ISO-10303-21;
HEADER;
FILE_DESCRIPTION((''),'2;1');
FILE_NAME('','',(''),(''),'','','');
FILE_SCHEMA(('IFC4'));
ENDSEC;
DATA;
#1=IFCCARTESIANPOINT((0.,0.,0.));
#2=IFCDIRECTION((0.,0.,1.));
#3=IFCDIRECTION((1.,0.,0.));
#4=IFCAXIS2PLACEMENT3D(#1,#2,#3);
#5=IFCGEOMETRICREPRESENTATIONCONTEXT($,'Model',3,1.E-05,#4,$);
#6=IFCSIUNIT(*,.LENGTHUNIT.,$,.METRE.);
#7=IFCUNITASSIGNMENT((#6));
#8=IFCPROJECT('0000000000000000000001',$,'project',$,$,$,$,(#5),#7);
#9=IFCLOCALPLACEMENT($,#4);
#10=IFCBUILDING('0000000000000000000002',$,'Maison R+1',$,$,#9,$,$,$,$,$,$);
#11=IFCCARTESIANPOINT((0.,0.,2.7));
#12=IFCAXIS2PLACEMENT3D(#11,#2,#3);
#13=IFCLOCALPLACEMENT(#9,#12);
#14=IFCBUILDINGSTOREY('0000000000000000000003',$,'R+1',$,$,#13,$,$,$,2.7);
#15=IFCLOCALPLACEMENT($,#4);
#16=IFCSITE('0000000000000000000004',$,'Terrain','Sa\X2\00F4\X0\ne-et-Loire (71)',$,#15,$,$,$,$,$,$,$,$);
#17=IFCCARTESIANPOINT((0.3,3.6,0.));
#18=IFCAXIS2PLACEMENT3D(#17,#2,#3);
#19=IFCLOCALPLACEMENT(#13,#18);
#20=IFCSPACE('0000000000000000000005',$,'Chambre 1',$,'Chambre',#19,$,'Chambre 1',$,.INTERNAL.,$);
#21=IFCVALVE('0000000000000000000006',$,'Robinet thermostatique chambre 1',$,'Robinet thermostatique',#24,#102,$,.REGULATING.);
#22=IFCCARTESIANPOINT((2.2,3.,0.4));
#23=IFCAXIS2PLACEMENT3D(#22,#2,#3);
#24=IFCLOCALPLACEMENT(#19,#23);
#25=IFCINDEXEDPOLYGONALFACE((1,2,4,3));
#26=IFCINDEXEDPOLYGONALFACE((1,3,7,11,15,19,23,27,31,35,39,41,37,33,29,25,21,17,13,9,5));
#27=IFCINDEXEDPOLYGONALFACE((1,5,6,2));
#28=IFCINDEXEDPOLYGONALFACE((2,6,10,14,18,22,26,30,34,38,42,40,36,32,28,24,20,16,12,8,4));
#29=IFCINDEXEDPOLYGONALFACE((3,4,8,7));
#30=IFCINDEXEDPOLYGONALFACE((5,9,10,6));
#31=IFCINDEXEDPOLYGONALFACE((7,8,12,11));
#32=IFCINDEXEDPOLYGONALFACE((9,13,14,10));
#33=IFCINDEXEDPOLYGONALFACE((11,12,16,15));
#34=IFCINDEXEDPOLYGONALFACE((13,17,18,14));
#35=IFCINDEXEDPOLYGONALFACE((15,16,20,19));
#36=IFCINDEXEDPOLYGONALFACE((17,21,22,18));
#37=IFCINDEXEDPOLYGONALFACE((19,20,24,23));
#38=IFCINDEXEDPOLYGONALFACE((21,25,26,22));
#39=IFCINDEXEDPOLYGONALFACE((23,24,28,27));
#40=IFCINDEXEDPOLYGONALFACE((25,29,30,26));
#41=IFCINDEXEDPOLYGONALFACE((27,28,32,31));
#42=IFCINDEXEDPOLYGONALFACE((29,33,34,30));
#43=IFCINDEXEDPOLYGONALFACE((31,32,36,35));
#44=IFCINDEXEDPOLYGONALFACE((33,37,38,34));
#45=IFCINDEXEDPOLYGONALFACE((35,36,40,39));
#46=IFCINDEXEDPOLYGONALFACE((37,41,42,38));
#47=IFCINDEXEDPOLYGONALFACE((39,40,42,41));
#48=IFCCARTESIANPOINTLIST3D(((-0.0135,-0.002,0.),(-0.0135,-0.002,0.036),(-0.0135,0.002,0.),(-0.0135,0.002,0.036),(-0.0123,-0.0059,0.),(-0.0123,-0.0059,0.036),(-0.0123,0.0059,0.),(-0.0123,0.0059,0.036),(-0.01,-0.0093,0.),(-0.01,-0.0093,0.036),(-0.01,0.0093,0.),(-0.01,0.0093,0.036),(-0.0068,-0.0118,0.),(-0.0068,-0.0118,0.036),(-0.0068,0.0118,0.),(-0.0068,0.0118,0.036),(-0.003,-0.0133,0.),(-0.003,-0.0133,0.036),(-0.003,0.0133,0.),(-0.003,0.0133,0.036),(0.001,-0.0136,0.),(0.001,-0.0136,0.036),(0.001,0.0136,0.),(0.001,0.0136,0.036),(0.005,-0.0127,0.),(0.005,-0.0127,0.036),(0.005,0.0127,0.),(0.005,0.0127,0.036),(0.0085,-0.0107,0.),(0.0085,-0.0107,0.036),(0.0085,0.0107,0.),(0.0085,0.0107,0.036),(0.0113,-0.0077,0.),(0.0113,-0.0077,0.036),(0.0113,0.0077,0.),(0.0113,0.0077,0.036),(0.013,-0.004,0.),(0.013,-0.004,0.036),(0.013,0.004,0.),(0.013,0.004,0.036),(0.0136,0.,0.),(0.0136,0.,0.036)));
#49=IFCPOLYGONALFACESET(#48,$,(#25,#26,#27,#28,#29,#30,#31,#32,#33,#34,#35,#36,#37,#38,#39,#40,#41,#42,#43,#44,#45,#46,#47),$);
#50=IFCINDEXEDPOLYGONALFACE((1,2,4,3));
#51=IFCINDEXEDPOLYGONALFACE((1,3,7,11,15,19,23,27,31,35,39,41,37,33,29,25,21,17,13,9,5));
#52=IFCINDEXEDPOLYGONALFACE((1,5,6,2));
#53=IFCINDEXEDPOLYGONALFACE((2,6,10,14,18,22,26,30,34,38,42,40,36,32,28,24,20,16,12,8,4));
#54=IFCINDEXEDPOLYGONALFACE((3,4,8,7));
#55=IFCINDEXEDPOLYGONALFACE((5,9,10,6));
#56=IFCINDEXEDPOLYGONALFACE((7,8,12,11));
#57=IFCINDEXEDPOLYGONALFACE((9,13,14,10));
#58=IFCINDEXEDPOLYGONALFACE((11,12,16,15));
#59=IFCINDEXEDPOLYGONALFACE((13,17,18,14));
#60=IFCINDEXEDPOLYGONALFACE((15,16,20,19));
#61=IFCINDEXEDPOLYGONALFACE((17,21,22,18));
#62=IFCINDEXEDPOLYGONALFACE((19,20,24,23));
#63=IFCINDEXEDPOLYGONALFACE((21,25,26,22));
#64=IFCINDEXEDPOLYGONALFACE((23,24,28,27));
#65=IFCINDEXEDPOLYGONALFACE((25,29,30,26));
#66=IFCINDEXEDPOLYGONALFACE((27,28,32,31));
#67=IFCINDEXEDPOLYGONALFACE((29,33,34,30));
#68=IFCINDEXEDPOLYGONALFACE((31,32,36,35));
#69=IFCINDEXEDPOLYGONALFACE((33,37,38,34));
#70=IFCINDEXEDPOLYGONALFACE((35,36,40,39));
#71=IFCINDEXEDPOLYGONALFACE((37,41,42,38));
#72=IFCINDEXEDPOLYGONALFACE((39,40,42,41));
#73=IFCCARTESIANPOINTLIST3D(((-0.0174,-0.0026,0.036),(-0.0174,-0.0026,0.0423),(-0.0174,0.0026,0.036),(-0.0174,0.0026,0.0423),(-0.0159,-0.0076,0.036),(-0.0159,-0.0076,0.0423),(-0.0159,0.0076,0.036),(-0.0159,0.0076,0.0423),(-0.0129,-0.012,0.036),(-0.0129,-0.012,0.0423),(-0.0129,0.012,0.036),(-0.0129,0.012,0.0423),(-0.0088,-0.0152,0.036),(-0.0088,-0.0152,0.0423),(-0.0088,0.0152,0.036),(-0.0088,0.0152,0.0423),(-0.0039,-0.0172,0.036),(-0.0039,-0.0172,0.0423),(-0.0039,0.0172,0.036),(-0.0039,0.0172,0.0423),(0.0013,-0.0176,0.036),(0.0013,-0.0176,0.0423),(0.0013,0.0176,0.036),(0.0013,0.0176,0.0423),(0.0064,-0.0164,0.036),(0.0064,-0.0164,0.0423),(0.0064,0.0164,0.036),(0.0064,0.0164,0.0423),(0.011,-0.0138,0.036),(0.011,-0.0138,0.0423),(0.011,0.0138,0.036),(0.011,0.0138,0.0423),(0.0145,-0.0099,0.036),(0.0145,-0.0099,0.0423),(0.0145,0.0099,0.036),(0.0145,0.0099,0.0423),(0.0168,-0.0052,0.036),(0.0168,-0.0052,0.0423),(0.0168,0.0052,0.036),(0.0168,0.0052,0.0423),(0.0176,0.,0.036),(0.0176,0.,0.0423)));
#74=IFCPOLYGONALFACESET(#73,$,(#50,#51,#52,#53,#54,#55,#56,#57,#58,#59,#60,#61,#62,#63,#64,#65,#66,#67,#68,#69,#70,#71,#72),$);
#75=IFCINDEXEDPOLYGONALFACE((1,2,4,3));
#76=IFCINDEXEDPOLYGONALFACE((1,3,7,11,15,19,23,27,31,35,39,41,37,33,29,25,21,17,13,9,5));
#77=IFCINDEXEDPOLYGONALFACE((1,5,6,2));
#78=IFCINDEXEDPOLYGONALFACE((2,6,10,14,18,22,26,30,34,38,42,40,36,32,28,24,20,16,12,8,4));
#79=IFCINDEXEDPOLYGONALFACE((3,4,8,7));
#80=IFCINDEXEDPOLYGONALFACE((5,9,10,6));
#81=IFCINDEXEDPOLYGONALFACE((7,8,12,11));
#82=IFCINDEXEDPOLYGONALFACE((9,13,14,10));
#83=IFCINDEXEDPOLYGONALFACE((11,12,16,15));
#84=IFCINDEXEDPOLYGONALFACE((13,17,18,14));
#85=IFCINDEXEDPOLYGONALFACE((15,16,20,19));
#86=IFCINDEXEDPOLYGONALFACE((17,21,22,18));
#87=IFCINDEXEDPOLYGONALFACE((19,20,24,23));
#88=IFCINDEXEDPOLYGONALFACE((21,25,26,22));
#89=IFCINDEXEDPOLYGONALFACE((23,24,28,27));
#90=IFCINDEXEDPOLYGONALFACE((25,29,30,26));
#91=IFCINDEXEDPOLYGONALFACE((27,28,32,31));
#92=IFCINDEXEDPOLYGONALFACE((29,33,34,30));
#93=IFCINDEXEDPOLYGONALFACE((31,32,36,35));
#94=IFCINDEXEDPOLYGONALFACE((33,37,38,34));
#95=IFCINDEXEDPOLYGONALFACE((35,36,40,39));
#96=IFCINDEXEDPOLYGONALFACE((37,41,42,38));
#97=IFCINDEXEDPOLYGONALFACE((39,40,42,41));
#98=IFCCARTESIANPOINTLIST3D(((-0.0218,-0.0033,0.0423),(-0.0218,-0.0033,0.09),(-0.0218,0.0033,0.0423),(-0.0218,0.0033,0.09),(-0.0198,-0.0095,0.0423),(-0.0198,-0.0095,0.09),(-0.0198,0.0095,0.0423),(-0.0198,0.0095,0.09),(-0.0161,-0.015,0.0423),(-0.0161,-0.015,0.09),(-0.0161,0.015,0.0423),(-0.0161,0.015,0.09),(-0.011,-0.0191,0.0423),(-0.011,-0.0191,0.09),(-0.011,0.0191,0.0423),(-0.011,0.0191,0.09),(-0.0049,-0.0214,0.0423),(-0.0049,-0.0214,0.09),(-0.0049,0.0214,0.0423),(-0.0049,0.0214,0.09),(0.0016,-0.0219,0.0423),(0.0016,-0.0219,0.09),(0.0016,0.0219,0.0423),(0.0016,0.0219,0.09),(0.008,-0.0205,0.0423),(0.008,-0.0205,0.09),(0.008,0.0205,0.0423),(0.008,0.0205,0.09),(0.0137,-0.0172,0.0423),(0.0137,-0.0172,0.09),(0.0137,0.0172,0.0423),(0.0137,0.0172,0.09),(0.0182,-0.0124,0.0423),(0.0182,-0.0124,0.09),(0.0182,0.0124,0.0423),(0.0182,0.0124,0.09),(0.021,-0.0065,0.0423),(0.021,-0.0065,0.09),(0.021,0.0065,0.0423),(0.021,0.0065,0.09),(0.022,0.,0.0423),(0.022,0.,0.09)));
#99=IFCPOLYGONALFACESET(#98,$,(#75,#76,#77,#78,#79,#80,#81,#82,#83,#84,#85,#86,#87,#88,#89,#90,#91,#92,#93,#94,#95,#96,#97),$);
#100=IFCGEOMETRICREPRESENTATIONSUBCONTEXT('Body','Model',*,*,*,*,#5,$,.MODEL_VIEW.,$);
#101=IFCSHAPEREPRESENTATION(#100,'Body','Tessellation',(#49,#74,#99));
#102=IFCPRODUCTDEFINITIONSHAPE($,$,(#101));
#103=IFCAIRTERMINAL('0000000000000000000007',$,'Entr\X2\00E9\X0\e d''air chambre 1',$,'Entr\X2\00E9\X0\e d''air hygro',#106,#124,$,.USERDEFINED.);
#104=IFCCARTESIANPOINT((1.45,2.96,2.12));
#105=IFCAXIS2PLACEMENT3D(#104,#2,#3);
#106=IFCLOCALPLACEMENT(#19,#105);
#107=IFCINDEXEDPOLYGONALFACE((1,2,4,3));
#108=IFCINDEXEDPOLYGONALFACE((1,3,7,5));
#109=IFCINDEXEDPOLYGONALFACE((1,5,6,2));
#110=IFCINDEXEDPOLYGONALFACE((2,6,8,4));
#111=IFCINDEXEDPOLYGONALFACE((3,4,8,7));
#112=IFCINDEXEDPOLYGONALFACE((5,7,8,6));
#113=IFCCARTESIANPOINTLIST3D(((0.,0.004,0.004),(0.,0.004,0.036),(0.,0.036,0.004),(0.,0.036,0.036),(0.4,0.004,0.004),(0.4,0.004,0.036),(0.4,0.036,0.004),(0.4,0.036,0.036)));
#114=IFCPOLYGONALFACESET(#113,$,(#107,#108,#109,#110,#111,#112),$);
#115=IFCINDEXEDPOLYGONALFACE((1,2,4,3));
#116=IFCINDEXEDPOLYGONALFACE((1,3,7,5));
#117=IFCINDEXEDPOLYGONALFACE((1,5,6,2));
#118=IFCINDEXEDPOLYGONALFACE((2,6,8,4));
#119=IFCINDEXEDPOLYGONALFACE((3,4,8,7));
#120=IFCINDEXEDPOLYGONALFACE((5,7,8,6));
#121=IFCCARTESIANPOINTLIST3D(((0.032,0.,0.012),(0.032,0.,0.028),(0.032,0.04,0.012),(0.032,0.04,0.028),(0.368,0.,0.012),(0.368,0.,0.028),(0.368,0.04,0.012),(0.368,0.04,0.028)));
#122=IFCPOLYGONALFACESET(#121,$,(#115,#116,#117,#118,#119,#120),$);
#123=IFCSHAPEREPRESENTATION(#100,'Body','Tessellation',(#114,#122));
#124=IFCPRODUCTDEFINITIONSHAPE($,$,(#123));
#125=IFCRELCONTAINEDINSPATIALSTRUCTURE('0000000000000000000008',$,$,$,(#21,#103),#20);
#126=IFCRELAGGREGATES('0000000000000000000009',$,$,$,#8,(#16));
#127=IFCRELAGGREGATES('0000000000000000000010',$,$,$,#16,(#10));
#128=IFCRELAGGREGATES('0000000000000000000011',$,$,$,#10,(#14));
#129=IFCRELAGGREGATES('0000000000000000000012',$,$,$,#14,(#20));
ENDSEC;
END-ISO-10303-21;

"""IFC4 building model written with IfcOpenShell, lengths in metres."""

from ifc_helpers import new_model, si_unit, frame, frame_2d, origin_with_axes, place, context, subcontext, project, spatial, rectangle, circle, extrude, element, save


model = new_model("IFC4")

# Units and contexts
model_context = context("Model", 3, precision=1e-05, world=origin_with_axes())
body_context = subcontext(model_context, "Body", "Model", "MODEL_VIEW")
ifc_project = project(units=[si_unit("LENGTHUNIT", "METRE")], contexts=[model_context])

# Site, building, storey
site_placement = place(None, origin_with_axes())
site = spatial("IfcSite", under=ifc_project, at=site_placement, Name="Terrain", Description="Saône-et-Loire (71)")
building_placement = place(None, origin_with_axes())
building = spatial("IfcBuilding", under=site, at=building_placement, Name="Maison R+1")
storey_placement = place(building_placement, frame((0.0, 0.0, 2.7), z_axis=(0.0, 0.0, 1.0), x_axis=(1.0, 0.0, 0.0)))
storey = spatial("IfcBuildingStorey", under=building, at=storey_placement, Name="R+1", Elevation=2.7)

# Shared definitions
space_placement = place(storey_placement, frame((0.3, 3.6, 0.0), z_axis=(0.0, 0.0, 1.0), x_axis=(1.0, 0.0, 0.0)))
space = spatial("IfcSpace", under=storey, at=space_placement, Name="Chambre 1", ObjectType="Chambre", LongName="Chambre 1", PredefinedType="INTERNAL")

# Valve
valve_1_placement = place(space_placement, frame((2.2, 3.0, 0.4), z_axis=(0.0, 0.0, 1.0), x_axis=(1.0, 0.0, 0.0)))
element("IfcValve", 1, at=valve_1_placement, inside=space, Name="Robinet thermostatique chambre 1", ObjectType="Robinet thermostatique", PredefinedType="REGULATING", context=body_context, shape_type="SweptSolid", body=[
    extrude(circle(Radius=0.0136), origin_with_axes(), (0.0, 0.0, 1.0), 0.036),
    extrude(circle(Radius=0.0176), frame((0.0, 0.0, 0.036), z_axis=(0.0, 0.0, 1.0), x_axis=(1.0, 0.0, 0.0)), (0.0, 0.0, 1.0), 0.0063),
    extrude(circle(Radius=0.022), frame((0.0, 0.0, 0.0423), z_axis=(0.0, 0.0, 1.0), x_axis=(1.0, 0.0, 0.0)), (0.0, 0.0, 1.0), 0.0477),
])

# Air terminal
air_terminal_placement = place(space_placement, frame((1.45, 2.96, 2.12), z_axis=(0.0, 0.0, 1.0), x_axis=(1.0, 0.0, 0.0)))
element("IfcAirTerminal", 2, at=air_terminal_placement, inside=space, Name="Entrée d'air chambre 1", ObjectType="Entrée d'air hygro", PredefinedType="USERDEFINED", context=body_context, shape_type="SweptSolid", body=[
    extrude(rectangle(XDim=0.4, YDim=0.032, at=frame_2d((0.2, 0.016))), frame((0.0, 0.004, 0.004), z_axis=(0.0, 0.0, 1.0), x_axis=(1.0, 0.0, 0.0)), (0.0, 0.0, 1.0), 0.032),
    extrude(rectangle(XDim=0.336, YDim=0.04, at=frame_2d((0.168, 0.02))), frame((0.032, 0.0, 0.012), z_axis=(0.0, 0.0, 1.0), x_axis=(1.0, 0.0, 0.0)), (0.0, 0.0, 1.0), 0.016),
])

save(model, "model.ifc")
